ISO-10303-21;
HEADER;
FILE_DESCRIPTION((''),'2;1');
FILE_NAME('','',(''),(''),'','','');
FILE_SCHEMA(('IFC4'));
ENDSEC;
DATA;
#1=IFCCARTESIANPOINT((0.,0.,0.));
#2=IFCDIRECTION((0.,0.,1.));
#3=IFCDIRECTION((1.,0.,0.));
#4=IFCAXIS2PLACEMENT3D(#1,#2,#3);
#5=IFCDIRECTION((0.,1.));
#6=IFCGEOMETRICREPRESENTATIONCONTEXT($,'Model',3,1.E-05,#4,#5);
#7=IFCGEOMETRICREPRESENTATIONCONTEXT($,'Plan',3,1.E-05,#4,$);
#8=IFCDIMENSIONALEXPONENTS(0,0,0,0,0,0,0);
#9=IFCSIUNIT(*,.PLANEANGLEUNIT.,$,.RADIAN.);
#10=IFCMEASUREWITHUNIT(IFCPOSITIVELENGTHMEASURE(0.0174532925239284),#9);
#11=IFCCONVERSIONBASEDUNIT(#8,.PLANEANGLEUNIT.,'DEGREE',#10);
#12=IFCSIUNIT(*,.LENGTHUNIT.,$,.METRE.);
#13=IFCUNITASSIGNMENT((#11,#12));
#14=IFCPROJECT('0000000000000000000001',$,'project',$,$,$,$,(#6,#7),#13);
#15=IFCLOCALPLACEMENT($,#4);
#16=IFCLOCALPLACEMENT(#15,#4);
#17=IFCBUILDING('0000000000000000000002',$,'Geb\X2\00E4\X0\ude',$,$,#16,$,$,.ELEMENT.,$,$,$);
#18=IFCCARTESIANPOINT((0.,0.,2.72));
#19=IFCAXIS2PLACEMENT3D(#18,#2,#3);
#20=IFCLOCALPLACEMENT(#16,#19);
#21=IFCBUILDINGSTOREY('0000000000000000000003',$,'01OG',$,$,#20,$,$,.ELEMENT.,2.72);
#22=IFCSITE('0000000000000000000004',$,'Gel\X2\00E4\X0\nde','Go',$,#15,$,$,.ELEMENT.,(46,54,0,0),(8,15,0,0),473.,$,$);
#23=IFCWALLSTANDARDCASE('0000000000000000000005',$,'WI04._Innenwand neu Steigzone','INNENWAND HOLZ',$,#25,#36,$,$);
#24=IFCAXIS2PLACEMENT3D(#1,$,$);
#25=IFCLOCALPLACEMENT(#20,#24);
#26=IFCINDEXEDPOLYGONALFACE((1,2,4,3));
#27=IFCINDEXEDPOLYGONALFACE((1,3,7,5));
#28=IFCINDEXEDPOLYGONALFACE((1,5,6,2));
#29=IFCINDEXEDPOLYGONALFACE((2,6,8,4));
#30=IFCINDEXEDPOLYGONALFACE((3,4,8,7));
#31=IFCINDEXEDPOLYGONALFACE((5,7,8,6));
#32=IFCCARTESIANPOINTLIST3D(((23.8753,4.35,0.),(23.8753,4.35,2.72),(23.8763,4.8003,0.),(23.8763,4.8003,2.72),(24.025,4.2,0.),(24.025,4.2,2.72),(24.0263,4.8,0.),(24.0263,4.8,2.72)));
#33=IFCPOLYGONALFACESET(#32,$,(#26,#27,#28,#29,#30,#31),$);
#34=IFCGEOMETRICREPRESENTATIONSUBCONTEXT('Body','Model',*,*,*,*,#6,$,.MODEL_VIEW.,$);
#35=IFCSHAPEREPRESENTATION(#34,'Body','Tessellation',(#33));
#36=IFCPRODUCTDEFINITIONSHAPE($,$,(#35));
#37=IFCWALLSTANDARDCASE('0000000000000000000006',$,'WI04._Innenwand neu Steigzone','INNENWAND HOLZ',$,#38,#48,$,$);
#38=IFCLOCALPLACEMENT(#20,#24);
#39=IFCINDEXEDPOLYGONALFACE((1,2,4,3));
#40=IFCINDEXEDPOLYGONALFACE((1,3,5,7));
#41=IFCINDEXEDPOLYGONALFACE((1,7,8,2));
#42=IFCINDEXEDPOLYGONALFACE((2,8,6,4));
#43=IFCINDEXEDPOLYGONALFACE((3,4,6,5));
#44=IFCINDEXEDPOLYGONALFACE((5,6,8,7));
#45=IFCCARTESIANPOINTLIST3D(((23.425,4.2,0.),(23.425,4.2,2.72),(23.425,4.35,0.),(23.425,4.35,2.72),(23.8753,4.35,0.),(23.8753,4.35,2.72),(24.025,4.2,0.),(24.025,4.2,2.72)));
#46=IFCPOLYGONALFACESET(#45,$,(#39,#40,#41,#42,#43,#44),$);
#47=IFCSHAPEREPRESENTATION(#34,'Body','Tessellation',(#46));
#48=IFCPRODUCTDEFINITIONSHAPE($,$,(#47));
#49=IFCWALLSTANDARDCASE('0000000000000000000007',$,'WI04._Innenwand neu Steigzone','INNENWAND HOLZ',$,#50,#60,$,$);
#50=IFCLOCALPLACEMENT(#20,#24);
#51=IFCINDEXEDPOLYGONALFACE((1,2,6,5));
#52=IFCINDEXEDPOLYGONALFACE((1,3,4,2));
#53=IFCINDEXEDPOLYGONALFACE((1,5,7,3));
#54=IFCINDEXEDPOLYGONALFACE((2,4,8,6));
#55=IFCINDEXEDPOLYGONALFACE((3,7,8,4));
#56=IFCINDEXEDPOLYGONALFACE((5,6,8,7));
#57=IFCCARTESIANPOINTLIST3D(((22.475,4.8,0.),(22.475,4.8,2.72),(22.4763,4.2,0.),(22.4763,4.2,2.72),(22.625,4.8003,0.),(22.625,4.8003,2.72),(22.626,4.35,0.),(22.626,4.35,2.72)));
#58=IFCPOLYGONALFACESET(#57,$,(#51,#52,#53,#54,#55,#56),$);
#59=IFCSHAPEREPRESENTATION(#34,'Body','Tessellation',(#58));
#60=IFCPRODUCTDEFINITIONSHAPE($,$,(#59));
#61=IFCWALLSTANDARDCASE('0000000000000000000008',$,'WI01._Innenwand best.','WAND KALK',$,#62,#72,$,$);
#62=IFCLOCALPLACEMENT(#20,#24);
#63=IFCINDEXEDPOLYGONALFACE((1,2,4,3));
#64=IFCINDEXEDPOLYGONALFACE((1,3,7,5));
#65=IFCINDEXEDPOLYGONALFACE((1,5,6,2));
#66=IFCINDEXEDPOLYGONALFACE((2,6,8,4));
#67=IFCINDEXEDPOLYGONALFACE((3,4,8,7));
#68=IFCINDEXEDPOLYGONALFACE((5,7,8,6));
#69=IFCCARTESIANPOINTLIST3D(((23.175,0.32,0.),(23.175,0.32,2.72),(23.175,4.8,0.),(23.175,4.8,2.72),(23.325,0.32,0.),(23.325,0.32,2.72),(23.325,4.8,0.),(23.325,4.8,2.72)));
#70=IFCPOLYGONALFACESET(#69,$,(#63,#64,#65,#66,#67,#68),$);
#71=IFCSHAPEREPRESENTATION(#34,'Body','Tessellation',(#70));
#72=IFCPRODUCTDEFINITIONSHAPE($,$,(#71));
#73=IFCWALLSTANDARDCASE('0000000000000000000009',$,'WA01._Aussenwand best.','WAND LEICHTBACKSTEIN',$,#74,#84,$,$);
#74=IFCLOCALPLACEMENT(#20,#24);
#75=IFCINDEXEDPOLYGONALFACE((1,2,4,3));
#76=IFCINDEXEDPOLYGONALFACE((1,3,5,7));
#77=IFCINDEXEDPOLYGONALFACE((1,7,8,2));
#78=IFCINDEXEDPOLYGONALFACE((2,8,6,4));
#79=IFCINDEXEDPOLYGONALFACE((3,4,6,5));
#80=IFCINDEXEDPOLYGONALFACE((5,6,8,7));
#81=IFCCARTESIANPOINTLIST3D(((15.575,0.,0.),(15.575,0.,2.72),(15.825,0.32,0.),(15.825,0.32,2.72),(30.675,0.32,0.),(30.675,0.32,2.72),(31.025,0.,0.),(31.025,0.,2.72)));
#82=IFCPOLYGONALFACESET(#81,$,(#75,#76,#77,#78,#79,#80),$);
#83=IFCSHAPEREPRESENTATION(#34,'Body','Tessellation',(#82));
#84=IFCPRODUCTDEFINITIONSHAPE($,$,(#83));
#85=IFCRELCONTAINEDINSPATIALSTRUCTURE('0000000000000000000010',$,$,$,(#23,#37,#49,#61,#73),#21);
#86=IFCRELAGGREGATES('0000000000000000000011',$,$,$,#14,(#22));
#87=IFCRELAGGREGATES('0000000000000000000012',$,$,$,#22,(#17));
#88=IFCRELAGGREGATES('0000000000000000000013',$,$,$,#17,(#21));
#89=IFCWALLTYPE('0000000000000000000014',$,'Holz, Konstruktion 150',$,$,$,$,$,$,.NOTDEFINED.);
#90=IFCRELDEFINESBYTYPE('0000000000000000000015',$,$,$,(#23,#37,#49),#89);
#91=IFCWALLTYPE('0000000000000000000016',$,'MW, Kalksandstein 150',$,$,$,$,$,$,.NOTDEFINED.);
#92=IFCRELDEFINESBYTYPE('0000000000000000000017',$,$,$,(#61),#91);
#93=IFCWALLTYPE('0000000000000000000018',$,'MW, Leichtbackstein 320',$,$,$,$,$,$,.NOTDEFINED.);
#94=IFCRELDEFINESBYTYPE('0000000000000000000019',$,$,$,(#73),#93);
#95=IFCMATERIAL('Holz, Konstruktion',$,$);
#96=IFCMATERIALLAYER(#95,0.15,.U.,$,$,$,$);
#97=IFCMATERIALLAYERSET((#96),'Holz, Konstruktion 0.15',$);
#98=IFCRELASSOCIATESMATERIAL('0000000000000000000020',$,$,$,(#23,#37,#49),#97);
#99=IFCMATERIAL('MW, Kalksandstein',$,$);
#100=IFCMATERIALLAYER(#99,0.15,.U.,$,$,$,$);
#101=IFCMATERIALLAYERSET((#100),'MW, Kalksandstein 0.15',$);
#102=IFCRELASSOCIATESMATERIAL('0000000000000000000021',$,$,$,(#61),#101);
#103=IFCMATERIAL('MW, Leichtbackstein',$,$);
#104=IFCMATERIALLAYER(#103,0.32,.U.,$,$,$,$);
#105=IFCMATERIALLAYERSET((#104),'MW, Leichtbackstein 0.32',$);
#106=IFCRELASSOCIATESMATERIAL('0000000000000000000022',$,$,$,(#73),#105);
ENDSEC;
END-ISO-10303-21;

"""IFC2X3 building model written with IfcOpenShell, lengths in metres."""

from ifc_helpers import new_model, entity, si_unit, converted_unit, direction, frame, origin_with_axes, place, context, subcontext, project, spatial, polyline, outline, extrude, material, layer, layer_set, layer_usage, type_object, element, save


model = new_model("IFC2X3")

# Units and contexts
model_context = context("Model", 3, precision=1e-05, world=origin_with_axes(), true_north=direction((0.0, 1.0)))
plan_context = context("Plan", 3, precision=1e-05, world=origin_with_axes())
body_context = subcontext(model_context, "Body", "Model", "MODEL_VIEW")
ifc_project = project(units=[converted_unit("PLANEANGLEUNIT", "DEGREE", entity("IfcPositiveLengthMeasure", 0.0174532925239284), si_unit("PLANEANGLEUNIT", "RADIAN"), dimensions=[0, 0, 0, 0, 0, 0, 0]), si_unit("LENGTHUNIT", "METRE")], contexts=[model_context, plan_context])

# Site, building, storey
site_placement = place(None, origin_with_axes())
site = spatial("IfcSite", under=ifc_project, at=site_placement, Name="Gelände", Description="Go", CompositionType="ELEMENT", RefLatitude=(46, 54, 0, 0), RefLongitude=(8, 15, 0, 0), RefElevation=473.0)
building_placement = place(site_placement, origin_with_axes())
building = spatial("IfcBuilding", under=site, at=building_placement, Name="Gebäude", CompositionType="ELEMENT")
storey_placement = place(building_placement, frame((0.0, 0.0, 2.72), z_axis=(0.0, 0.0, 1.0), x_axis=(1.0, 0.0, 0.0)))
storey = spatial("IfcBuildingStorey", under=building, at=storey_placement, Name="01OG", CompositionType="ELEMENT", Elevation=2.72)

# Shared definitions
ifc_material_1 = material(Name="Holz, Konstruktion")

# Walls
ifc_layer_1 = layer(ifc_material_1, 0.15, ventilated="UNKNOWN")
ifc_layer_set_1 = layer_set([ifc_layer_1], Name="Holz, Konstruktion 0.15")
wall_type_1 = type_object("IfcWallType", Name="Holz, Konstruktion 150", PredefinedType="NOTDEFINED")
ifc_layer_usage_1 = layer_usage(ifc_layer_set_1, "AXIS2", "POSITIVE", 0.0)
wall_1_placement = place(storey_placement, frame((24.025, 4.2, 0.0), z_axis=(0.0, 0.0, 1.0), x_axis=(0.002118, 0.999998, 0.0)))
element("IfcWallStandardCase", 1, at=wall_1_placement, inside=storey, type_object=wall_type_1, material=ifc_layer_usage_1, Name="WI04._Innenwand neu Steigzone", Description="INNENWAND HOLZ", context=body_context, shape_type="SweptSolid", body=[
    extrude(outline(polyline([(0.0, 0.0), (0.6, 0.0), (0.6, 0.15), (0.1497, 0.15), (0.0, 0.0)])), origin_with_axes(), (0.0, 0.0, 1.0), 2.72),
])
ifc_layer_usage_2 = layer_usage(ifc_layer_set_1, "AXIS2", "POSITIVE", 0.0)
wall_2_placement = place(storey_placement, frame((23.425, 4.2, 0.0), z_axis=(0.0, 0.0, 1.0), x_axis=(1.0, 0.0, 0.0)))
element("IfcWallStandardCase", 2, at=wall_2_placement, inside=storey, type_object=wall_type_1, material=ifc_layer_usage_2, Name="WI04._Innenwand neu Steigzone", Description="INNENWAND HOLZ", context=body_context, shape_type="SweptSolid", body=[
    extrude(outline(polyline([(0.0, 0.0), (0.6, 0.0), (0.4503, 0.15), (0.0, 0.15), (0.0, 0.0)])), origin_with_axes(), (0.0, 0.0, 1.0), 2.72),
])
ifc_layer_usage_3 = layer_usage(ifc_layer_set_1, "AXIS2", "POSITIVE", 0.0)
wall_3_placement = place(storey_placement, frame((22.475, 4.8, 0.0), z_axis=(0.0, 0.0, 1.0), x_axis=(0.002118, -0.999998, 0.0)))
element("IfcWallStandardCase", 3, at=wall_3_placement, inside=storey, type_object=wall_type_1, material=ifc_layer_usage_3, Name="WI04._Innenwand neu Steigzone", Description="INNENWAND HOLZ", context=body_context, shape_type="SweptSolid", body=[
    extrude(outline(polyline([(0.0, 0.0), (0.6, 0.0), (0.4503, 0.15), (0.0, 0.15), (0.0, 0.0)])), origin_with_axes(), (0.0, 0.0, 1.0), 2.72),
])
ifc_material_2 = material(Name="MW, Kalksandstein")
ifc_layer_2 = layer(ifc_material_2, 0.15, ventilated="UNKNOWN")
ifc_layer_set_2 = layer_set([ifc_layer_2], Name="MW, Kalksandstein 0.15")
ifc_layer_usage_4 = layer_usage(ifc_layer_set_2, "AXIS2", "POSITIVE", 0.0)
wall_type_2 = type_object("IfcWallType", Name="MW, Kalksandstein 150", PredefinedType="NOTDEFINED")
wall_4_placement = place(storey_placement, frame((23.325, 0.32, 0.0), z_axis=(0.0, 0.0, 1.0), x_axis=(0.0, 1.0, 0.0)))
element("IfcWallStandardCase", 4, at=wall_4_placement, inside=storey, type_object=wall_type_2, material=ifc_layer_usage_4, Name="WI01._Innenwand best.", Description="WAND KALK", context=body_context, shape_type="SweptSolid", body=[
    extrude(outline(polyline([(0.0, 0.0), (4.48, 0.0), (4.48, 0.15), (0.0, 0.15), (0.0, 0.0)])), origin_with_axes(), (0.0, 0.0, 1.0), 2.72),
])
ifc_material_3 = material(Name="MW, Leichtbackstein")
ifc_layer_3 = layer(ifc_material_3, 0.32, ventilated="UNKNOWN")
ifc_layer_set_3 = layer_set([ifc_layer_3], Name="MW, Leichtbackstein 0.32")
ifc_layer_usage_5 = layer_usage(ifc_layer_set_3, "AXIS2", "NEGATIVE", 0.32)
wall_type_3 = type_object("IfcWallType", Name="MW, Leichtbackstein 320", PredefinedType="NOTDEFINED")
wall_5_placement = place(storey_placement, frame((30.675, 0.32, 0.0), z_axis=(0.0, 0.0, 1.0), x_axis=(-1.0, 0.0, 0.0)))
element("IfcWallStandardCase", 5, at=wall_5_placement, inside=storey, type_object=wall_type_3, material=ifc_layer_usage_5, Name="WA01._Aussenwand best.", Description="WAND LEICHTBACKSTEIN", context=body_context, shape_type="SweptSolid", body=[
    extrude(outline(polyline([(0.0, 0.0), (14.85, 0.0), (15.1, 0.32), (-0.35, 0.32), (0.0, 0.0)])), origin_with_axes(), (0.0, 0.0, 1.0), 2.72),
])

save(model, "model.ifc")
